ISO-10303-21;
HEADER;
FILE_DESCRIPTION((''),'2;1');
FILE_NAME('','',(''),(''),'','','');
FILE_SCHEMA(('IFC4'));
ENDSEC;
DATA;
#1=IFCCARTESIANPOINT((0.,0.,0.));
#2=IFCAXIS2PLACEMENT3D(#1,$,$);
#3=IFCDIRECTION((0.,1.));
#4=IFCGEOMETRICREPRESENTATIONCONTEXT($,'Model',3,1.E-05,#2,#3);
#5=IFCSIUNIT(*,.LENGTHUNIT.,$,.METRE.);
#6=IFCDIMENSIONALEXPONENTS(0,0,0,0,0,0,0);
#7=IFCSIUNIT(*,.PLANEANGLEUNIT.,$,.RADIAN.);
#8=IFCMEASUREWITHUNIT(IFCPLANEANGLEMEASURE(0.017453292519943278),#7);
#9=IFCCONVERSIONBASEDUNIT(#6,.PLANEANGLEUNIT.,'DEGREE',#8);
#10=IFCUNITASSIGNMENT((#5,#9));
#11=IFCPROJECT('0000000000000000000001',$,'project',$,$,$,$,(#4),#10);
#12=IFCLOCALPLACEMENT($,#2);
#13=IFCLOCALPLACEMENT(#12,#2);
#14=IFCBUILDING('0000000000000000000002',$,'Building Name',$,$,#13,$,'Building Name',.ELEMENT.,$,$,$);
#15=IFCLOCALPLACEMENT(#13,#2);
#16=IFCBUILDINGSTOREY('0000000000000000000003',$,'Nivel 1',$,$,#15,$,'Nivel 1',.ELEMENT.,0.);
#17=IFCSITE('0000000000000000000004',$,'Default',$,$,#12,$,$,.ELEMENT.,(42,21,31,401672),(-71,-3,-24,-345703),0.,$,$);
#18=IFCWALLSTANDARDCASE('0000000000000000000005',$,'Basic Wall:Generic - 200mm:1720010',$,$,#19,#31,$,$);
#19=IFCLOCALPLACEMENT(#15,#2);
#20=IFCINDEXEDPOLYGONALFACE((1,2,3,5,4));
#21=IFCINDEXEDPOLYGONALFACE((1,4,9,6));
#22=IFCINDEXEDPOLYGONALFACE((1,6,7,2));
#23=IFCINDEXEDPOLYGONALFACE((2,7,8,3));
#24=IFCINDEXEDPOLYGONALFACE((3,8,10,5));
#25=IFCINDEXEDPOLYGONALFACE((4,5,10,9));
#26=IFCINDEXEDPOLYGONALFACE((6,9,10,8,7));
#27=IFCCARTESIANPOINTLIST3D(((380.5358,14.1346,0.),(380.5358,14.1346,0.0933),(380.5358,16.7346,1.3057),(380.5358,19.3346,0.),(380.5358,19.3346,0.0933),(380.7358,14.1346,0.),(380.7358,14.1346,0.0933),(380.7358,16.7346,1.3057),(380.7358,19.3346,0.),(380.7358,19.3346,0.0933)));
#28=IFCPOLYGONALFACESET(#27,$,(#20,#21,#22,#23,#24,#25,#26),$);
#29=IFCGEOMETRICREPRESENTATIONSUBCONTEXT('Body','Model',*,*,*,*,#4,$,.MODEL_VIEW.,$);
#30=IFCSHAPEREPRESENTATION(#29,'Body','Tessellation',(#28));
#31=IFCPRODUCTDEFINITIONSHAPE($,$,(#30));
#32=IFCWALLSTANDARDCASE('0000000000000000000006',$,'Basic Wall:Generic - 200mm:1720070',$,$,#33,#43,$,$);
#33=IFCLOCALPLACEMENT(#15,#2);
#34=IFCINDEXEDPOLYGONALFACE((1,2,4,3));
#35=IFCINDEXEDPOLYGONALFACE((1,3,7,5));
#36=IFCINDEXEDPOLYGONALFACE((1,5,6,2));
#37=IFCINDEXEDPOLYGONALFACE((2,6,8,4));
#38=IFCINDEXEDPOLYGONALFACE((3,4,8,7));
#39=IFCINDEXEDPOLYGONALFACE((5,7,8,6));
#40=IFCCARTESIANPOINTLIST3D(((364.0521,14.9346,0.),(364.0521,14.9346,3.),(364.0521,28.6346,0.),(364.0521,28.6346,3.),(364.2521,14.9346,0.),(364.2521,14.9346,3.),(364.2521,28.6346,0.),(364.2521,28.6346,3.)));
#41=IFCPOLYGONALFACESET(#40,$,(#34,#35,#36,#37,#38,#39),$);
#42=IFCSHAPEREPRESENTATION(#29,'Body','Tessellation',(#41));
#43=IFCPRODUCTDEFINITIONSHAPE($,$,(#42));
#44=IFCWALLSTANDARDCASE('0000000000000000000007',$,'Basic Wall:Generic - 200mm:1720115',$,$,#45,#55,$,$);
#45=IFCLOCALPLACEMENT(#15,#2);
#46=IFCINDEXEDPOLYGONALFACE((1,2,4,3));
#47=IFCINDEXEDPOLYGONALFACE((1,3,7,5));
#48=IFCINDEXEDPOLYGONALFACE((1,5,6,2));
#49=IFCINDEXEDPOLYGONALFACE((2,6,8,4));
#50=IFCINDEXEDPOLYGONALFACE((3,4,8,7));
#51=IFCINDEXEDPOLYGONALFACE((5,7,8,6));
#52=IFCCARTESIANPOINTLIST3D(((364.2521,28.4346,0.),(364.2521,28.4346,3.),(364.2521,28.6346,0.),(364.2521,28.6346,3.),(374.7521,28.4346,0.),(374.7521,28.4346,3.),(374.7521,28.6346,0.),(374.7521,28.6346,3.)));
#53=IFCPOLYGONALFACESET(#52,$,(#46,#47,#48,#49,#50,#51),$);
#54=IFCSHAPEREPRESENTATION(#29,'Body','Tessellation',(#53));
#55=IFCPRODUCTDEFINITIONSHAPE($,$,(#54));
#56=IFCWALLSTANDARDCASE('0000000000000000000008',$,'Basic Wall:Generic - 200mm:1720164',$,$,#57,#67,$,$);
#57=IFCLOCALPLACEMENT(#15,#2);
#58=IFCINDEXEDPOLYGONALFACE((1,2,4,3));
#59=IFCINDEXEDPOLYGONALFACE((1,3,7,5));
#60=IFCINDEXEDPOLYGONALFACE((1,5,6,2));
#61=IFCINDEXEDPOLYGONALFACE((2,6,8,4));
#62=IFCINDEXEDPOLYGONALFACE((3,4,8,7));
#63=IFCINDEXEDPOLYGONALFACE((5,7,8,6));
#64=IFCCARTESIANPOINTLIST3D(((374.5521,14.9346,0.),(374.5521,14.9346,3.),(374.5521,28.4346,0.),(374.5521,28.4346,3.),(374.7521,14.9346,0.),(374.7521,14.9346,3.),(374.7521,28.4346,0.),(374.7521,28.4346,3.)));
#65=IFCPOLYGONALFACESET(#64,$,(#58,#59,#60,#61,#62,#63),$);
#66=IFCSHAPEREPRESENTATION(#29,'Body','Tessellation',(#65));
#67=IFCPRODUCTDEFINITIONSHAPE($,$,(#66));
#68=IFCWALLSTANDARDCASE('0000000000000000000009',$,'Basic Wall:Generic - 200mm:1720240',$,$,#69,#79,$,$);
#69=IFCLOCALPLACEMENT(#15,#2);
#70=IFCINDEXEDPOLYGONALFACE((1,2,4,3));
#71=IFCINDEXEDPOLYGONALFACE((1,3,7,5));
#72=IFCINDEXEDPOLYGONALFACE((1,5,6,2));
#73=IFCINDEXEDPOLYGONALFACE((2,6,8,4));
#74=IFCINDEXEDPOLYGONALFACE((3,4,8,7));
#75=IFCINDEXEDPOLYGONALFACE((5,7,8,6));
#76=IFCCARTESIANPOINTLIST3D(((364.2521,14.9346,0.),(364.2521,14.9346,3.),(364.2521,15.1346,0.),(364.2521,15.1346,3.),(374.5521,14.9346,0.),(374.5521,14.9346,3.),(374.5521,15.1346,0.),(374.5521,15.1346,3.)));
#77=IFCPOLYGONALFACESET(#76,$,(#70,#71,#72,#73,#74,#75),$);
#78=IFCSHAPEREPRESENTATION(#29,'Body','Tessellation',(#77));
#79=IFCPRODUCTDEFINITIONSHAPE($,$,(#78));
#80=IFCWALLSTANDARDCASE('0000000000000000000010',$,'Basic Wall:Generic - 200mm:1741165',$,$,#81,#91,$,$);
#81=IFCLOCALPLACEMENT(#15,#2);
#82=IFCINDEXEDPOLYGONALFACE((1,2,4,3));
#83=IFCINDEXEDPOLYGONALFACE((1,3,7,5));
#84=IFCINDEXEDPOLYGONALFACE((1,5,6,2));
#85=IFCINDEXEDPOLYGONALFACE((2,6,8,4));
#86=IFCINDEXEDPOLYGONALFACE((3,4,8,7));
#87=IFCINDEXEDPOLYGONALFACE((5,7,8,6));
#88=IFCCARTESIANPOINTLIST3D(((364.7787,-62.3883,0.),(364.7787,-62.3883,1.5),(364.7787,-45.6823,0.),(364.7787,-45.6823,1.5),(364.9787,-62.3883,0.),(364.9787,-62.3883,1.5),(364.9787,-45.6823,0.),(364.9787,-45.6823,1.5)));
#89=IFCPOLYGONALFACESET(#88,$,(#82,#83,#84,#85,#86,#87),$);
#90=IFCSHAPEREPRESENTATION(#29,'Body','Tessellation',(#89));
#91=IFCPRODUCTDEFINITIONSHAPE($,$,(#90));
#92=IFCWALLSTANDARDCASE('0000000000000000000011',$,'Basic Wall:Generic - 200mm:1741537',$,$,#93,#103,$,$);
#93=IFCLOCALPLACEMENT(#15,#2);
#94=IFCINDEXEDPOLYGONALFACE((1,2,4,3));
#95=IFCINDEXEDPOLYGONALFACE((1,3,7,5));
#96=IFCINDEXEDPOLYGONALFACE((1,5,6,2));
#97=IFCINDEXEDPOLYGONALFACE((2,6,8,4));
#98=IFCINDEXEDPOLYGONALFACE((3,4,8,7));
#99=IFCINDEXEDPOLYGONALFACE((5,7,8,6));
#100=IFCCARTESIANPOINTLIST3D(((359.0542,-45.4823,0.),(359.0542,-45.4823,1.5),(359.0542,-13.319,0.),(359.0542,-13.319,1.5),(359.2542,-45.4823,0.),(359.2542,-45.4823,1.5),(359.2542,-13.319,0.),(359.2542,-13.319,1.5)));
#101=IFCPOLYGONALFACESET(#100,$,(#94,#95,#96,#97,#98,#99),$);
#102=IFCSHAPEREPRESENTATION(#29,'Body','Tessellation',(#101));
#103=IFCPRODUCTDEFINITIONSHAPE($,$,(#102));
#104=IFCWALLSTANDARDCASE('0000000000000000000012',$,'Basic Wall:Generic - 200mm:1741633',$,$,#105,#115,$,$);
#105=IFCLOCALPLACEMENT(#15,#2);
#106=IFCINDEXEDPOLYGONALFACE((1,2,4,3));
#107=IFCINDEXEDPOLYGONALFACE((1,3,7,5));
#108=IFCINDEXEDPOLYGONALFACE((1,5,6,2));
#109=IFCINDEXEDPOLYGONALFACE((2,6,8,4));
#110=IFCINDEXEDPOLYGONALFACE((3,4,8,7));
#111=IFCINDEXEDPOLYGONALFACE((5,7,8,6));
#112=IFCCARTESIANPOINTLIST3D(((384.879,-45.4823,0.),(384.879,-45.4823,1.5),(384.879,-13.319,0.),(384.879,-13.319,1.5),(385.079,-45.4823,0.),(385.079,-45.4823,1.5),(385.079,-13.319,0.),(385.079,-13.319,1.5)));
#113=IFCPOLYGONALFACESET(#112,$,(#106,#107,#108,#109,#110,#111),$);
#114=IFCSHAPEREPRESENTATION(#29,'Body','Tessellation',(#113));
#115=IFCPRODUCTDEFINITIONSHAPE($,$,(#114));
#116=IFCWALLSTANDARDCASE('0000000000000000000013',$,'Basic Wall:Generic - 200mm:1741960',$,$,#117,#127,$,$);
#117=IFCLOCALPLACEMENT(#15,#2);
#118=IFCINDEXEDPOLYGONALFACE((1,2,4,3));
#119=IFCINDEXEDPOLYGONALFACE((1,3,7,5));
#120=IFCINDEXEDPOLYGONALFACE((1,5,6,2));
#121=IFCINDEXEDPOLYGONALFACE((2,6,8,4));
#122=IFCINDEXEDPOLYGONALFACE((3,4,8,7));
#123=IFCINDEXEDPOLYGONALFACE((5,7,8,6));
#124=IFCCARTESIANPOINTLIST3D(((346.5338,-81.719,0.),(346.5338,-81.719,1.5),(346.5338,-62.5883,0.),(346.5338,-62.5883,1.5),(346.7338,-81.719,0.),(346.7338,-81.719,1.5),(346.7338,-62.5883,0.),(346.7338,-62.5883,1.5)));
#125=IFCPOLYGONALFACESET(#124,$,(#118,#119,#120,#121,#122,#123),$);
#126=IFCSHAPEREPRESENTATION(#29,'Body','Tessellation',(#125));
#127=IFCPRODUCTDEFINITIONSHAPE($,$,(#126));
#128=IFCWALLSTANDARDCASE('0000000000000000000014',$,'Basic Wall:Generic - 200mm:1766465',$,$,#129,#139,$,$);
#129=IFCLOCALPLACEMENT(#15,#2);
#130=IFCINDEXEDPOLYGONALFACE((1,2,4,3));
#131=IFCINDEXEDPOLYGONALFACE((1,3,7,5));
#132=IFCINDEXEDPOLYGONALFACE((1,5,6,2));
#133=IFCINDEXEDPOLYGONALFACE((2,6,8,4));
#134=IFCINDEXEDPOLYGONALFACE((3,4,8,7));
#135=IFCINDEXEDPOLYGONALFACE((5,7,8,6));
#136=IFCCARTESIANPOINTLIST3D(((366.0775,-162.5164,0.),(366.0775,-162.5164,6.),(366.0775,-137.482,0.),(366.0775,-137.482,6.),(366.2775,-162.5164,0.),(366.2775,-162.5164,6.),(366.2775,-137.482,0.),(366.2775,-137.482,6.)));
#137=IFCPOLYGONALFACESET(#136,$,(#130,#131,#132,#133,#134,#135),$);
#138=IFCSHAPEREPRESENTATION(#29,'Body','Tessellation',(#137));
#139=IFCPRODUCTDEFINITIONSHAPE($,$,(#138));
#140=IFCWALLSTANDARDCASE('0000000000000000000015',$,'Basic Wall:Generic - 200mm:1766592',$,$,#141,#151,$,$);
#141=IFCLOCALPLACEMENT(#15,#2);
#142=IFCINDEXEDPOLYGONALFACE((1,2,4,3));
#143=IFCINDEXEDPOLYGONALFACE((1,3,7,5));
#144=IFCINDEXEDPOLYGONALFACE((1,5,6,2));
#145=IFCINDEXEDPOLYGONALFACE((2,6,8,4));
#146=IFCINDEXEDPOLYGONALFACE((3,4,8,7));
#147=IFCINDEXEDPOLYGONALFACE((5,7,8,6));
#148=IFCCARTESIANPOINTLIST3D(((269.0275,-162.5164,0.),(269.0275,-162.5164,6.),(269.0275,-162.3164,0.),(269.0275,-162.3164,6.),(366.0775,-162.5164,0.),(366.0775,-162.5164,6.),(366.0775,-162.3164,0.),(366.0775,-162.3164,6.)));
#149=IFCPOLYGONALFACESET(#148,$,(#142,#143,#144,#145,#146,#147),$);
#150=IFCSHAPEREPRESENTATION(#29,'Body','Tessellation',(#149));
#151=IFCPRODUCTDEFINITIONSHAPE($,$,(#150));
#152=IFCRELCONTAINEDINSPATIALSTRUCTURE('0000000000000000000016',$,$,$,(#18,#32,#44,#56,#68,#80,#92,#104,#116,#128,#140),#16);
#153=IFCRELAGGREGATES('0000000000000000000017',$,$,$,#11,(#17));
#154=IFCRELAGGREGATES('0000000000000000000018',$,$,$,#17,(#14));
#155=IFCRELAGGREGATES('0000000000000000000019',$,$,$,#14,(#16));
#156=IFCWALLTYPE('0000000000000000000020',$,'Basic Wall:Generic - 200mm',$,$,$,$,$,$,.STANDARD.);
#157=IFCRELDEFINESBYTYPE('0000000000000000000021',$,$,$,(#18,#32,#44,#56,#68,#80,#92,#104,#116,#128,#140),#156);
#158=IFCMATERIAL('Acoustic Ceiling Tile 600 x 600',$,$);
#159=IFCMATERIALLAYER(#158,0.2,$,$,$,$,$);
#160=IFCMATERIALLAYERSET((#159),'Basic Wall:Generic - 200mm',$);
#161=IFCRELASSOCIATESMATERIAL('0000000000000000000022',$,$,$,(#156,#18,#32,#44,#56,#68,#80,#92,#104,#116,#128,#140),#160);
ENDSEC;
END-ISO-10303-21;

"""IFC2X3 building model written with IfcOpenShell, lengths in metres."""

from ifc_helpers import new_model, entity, si_unit, converted_unit, direction, frame, frame_2d, origin, place, context, subcontext, project, spatial, polyline, rectangle, extrude, clip, bounded_halfspace, material, layer, layer_set, layer_usage, type_object, element, save


model = new_model("IFC2X3")

# Units and contexts
model_context = context("Model", 3, precision=1e-05, world=origin(), true_north=direction((0.0, 1.0)))
body_context = subcontext(model_context, "Body", "Model", "MODEL_VIEW")
ifc_project = project(units=[si_unit("LENGTHUNIT", "METRE"), converted_unit("PLANEANGLEUNIT", "DEGREE", entity("IfcPlaneAngleMeasure", 0.017453292519943278), si_unit("PLANEANGLEUNIT", "RADIAN"), dimensions=[0, 0, 0, 0, 0, 0, 0])], contexts=[model_context])

# Site, building, storey
site_placement = place(None, origin())
site = spatial("IfcSite", under=ifc_project, at=site_placement, Name="Default", CompositionType="ELEMENT", RefLatitude=(42, 21, 31, 401672), RefLongitude=(-71, -3, -24, -345703), RefElevation=0.0)
building_placement = place(site_placement, origin())
building = spatial("IfcBuilding", under=site, at=building_placement, Name="Building Name", LongName="Building Name", CompositionType="ELEMENT")
storey_placement = place(building_placement, origin())
storey = spatial("IfcBuildingStorey", under=building, at=storey_placement, Name="Nivel 1", LongName="Nivel 1", CompositionType="ELEMENT", Elevation=0.0)

# Walls
ifc_material_1 = material(Name="Acoustic Ceiling Tile 600 x 600")
ifc_layer_1 = layer(ifc_material_1, 0.2)
ifc_layer_set_1 = layer_set([ifc_layer_1], Name="Basic Wall:Generic - 200mm")
wall_type_1 = type_object("IfcWallType", Name="Basic Wall:Generic - 200mm", PredefinedType="STANDARD", material=ifc_layer_set_1)
ifc_layer_usage_1 = layer_usage(ifc_layer_set_1, "AXIS2", "NEGATIVE", 0.1)
wall_1_placement = place(storey_placement, frame((380.6358, 14.1346, 0.0), z_axis=(0.0, 0.0, 1.0), x_axis=(0.0, 1.0, 0.0)))
element("IfcWallStandardCase", 1, at=wall_1_placement, inside=storey, type_object=wall_type_1, material=ifc_layer_usage_1, Name="Basic Wall:Generic - 200mm:1720010", context=body_context, shape_type="Clipping", body=[
    clip(clip(extrude(rectangle(XDim=5.2, YDim=0.2, at=frame_2d((2.6, 0.0), x_axis=(-1.0, 0.0))), origin(), (0.0, 0.0, 1.0), 1.3057), bounded_halfspace(frame((2.6, -0.1, 1.3057), z_axis=(0.422618, 0.0, 0.906308), x_axis=(0.0, 1.0, 0.0)), False, frame((2.6, -0.1, 1.3057)), polyline([(0.0, 0.0), (2.6, 0.0), (2.6, 0.2), (0.0, 0.2), (0.0, 0.0)]))), bounded_halfspace(frame((0.0, -0.1, 0.0933), z_axis=(-0.422618, 0.0, 0.906308), x_axis=(0.0, -1.0, 0.0)), False, frame((0.0, -0.1, 0.0933)), polyline([(0.0, 0.0), (2.6, 0.0), (2.6, 0.2), (0.0, 0.2), (0.0, 0.0)]))),
])
ifc_layer_usage_2 = layer_usage(ifc_layer_set_1, "AXIS2", "NEGATIVE", 0.1)
wall_2_placement = place(storey_placement, frame((364.1521, 14.9346, 0.0), z_axis=(0.0, 0.0, 1.0), x_axis=(0.0, 1.0, 0.0)))
element("IfcWallStandardCase", 2, at=wall_2_placement, inside=storey, type_object=wall_type_1, material=ifc_layer_usage_2, Name="Basic Wall:Generic - 200mm:1720070", context=body_context, shape_type="SweptSolid", body=[
    extrude(rectangle(XDim=13.7, YDim=0.2, at=frame_2d((6.85, 0.0), x_axis=(-1.0, 0.0))), origin(), (0.0, 0.0, 1.0), 3.0),
])
ifc_layer_usage_3 = layer_usage(ifc_layer_set_1, "AXIS2", "NEGATIVE", 0.1)
wall_3_placement = place(storey_placement, frame((364.2521, 28.5346, 0.0)))
element("IfcWallStandardCase", 3, at=wall_3_placement, inside=storey, type_object=wall_type_1, material=ifc_layer_usage_3, Name="Basic Wall:Generic - 200mm:1720115", context=body_context, shape_type="SweptSolid", body=[
    extrude(rectangle(XDim=10.5, YDim=0.2, at=frame_2d((5.25, 0.0), x_axis=(-1.0, 0.0))), origin(), (0.0, 0.0, 1.0), 3.0),
])
ifc_layer_usage_4 = layer_usage(ifc_layer_set_1, "AXIS2", "NEGATIVE", 0.1)
wall_4_placement = place(storey_placement, frame((374.6521, 28.4346, 0.0), z_axis=(0.0, 0.0, 1.0), x_axis=(0.0, -1.0, 0.0)))
element("IfcWallStandardCase", 4, at=wall_4_placement, inside=storey, type_object=wall_type_1, material=ifc_layer_usage_4, Name="Basic Wall:Generic - 200mm:1720164", context=body_context, shape_type="SweptSolid", body=[
    extrude(rectangle(XDim=13.5, YDim=0.2, at=frame_2d((6.75, 0.0), x_axis=(-1.0, 0.0))), origin(), (0.0, 0.0, 1.0), 3.0),
])
ifc_layer_usage_5 = layer_usage(ifc_layer_set_1, "AXIS2", "NEGATIVE", 0.1)
wall_5_placement = place(storey_placement, frame((374.5521, 15.0346, 0.0), z_axis=(0.0, 0.0, 1.0), x_axis=(-1.0, 0.0, 0.0)))
element("IfcWallStandardCase", 5, at=wall_5_placement, inside=storey, type_object=wall_type_1, material=ifc_layer_usage_5, Name="Basic Wall:Generic - 200mm:1720240", context=body_context, shape_type="SweptSolid", body=[
    extrude(rectangle(XDim=10.3, YDim=0.2, at=frame_2d((5.15, 0.0), x_axis=(-1.0, 0.0))), origin(), (0.0, 0.0, 1.0), 3.0),
])
ifc_layer_usage_6 = layer_usage(ifc_layer_set_1, "AXIS2", "NEGATIVE", 0.1)
wall_6_placement = place(storey_placement, frame((364.8787, -62.3883, 0.0), z_axis=(0.0, 0.0, 1.0), x_axis=(0.0, 1.0, 0.0)))
element("IfcWallStandardCase", 6, at=wall_6_placement, inside=storey, type_object=wall_type_1, material=ifc_layer_usage_6, Name="Basic Wall:Generic - 200mm:1741165", context=body_context, shape_type="SweptSolid", body=[
    extrude(rectangle(XDim=16.706, YDim=0.2, at=frame_2d((8.353, 0.0), x_axis=(-1.0, 0.0))), origin(), (0.0, 0.0, 1.0), 1.5),
])
ifc_layer_usage_7 = layer_usage(ifc_layer_set_1, "AXIS2", "NEGATIVE", 0.1)
wall_7_placement = place(storey_placement, frame((359.1542, -13.319, 0.0), z_axis=(0.0, 0.0, 1.0), x_axis=(0.0, -1.0, 0.0)))
element("IfcWallStandardCase", 7, at=wall_7_placement, inside=storey, type_object=wall_type_1, material=ifc_layer_usage_7, Name="Basic Wall:Generic - 200mm:1741537", context=body_context, shape_type="SweptSolid", body=[
    extrude(rectangle(XDim=32.1633, YDim=0.2, at=frame_2d((16.0816, 0.0), x_axis=(-1.0, 0.0))), origin(), (0.0, 0.0, 1.0), 1.5),
])
ifc_layer_usage_8 = layer_usage(ifc_layer_set_1, "AXIS2", "NEGATIVE", 0.1)
wall_8_placement = place(storey_placement, frame((384.979, -45.4823, 0.0), z_axis=(0.0, 0.0, 1.0), x_axis=(0.0, 1.0, 0.0)))
element("IfcWallStandardCase", 8, at=wall_8_placement, inside=storey, type_object=wall_type_1, material=ifc_layer_usage_8, Name="Basic Wall:Generic - 200mm:1741633", context=body_context, shape_type="SweptSolid", body=[
    extrude(rectangle(XDim=32.1633, YDim=0.2, at=frame_2d((16.0816, 0.0), x_axis=(-1.0, 0.0))), origin(), (0.0, 0.0, 1.0), 1.5),
])
ifc_layer_usage_9 = layer_usage(ifc_layer_set_1, "AXIS2", "NEGATIVE", 0.1)
wall_9_placement = place(storey_placement, frame((346.6338, -81.719, 0.0), z_axis=(0.0, 0.0, 1.0), x_axis=(0.0, 1.0, 0.0)))
element("IfcWallStandardCase", 9, at=wall_9_placement, inside=storey, type_object=wall_type_1, material=ifc_layer_usage_9, Name="Basic Wall:Generic - 200mm:1741960", context=body_context, shape_type="SweptSolid", body=[
    extrude(rectangle(XDim=19.1307, YDim=0.2, at=frame_2d((9.5654, 0.0), x_axis=(-1.0, 0.0))), origin(), (0.0, 0.0, 1.0), 1.5),
])
ifc_layer_usage_10 = layer_usage(ifc_layer_set_1, "AXIS2", "NEGATIVE", 0.1)
wall_10_placement = place(storey_placement, frame((366.1775, -137.482, 0.0), z_axis=(0.0, 0.0, 1.0), x_axis=(0.0, -1.0, 0.0)))
element("IfcWallStandardCase", 10, at=wall_10_placement, inside=storey, type_object=wall_type_1, material=ifc_layer_usage_10, Name="Basic Wall:Generic - 200mm:1766465", context=body_context, shape_type="SweptSolid", body=[
    extrude(rectangle(XDim=25.0344, YDim=0.2, at=frame_2d((12.5172, 0.0), x_axis=(-1.0, 0.0))), origin(), (0.0, 0.0, 1.0), 6.0),
])
ifc_layer_usage_11 = layer_usage(ifc_layer_set_1, "AXIS2", "NEGATIVE", 0.1)
wall_11_placement = place(storey_placement, frame((366.0775, -162.4164, 0.0), z_axis=(0.0, 0.0, 1.0), x_axis=(-1.0, 0.0, 0.0)))
element("IfcWallStandardCase", 11, at=wall_11_placement, inside=storey, type_object=wall_type_1, material=ifc_layer_usage_11, Name="Basic Wall:Generic - 200mm:1766592", context=body_context, shape_type="SweptSolid", body=[
    extrude(rectangle(XDim=97.05, YDim=0.2, at=frame_2d((48.525, 0.0), x_axis=(-1.0, 0.0))), origin(), (0.0, 0.0, 1.0), 6.0),
])

save(model, "model.ifc")
